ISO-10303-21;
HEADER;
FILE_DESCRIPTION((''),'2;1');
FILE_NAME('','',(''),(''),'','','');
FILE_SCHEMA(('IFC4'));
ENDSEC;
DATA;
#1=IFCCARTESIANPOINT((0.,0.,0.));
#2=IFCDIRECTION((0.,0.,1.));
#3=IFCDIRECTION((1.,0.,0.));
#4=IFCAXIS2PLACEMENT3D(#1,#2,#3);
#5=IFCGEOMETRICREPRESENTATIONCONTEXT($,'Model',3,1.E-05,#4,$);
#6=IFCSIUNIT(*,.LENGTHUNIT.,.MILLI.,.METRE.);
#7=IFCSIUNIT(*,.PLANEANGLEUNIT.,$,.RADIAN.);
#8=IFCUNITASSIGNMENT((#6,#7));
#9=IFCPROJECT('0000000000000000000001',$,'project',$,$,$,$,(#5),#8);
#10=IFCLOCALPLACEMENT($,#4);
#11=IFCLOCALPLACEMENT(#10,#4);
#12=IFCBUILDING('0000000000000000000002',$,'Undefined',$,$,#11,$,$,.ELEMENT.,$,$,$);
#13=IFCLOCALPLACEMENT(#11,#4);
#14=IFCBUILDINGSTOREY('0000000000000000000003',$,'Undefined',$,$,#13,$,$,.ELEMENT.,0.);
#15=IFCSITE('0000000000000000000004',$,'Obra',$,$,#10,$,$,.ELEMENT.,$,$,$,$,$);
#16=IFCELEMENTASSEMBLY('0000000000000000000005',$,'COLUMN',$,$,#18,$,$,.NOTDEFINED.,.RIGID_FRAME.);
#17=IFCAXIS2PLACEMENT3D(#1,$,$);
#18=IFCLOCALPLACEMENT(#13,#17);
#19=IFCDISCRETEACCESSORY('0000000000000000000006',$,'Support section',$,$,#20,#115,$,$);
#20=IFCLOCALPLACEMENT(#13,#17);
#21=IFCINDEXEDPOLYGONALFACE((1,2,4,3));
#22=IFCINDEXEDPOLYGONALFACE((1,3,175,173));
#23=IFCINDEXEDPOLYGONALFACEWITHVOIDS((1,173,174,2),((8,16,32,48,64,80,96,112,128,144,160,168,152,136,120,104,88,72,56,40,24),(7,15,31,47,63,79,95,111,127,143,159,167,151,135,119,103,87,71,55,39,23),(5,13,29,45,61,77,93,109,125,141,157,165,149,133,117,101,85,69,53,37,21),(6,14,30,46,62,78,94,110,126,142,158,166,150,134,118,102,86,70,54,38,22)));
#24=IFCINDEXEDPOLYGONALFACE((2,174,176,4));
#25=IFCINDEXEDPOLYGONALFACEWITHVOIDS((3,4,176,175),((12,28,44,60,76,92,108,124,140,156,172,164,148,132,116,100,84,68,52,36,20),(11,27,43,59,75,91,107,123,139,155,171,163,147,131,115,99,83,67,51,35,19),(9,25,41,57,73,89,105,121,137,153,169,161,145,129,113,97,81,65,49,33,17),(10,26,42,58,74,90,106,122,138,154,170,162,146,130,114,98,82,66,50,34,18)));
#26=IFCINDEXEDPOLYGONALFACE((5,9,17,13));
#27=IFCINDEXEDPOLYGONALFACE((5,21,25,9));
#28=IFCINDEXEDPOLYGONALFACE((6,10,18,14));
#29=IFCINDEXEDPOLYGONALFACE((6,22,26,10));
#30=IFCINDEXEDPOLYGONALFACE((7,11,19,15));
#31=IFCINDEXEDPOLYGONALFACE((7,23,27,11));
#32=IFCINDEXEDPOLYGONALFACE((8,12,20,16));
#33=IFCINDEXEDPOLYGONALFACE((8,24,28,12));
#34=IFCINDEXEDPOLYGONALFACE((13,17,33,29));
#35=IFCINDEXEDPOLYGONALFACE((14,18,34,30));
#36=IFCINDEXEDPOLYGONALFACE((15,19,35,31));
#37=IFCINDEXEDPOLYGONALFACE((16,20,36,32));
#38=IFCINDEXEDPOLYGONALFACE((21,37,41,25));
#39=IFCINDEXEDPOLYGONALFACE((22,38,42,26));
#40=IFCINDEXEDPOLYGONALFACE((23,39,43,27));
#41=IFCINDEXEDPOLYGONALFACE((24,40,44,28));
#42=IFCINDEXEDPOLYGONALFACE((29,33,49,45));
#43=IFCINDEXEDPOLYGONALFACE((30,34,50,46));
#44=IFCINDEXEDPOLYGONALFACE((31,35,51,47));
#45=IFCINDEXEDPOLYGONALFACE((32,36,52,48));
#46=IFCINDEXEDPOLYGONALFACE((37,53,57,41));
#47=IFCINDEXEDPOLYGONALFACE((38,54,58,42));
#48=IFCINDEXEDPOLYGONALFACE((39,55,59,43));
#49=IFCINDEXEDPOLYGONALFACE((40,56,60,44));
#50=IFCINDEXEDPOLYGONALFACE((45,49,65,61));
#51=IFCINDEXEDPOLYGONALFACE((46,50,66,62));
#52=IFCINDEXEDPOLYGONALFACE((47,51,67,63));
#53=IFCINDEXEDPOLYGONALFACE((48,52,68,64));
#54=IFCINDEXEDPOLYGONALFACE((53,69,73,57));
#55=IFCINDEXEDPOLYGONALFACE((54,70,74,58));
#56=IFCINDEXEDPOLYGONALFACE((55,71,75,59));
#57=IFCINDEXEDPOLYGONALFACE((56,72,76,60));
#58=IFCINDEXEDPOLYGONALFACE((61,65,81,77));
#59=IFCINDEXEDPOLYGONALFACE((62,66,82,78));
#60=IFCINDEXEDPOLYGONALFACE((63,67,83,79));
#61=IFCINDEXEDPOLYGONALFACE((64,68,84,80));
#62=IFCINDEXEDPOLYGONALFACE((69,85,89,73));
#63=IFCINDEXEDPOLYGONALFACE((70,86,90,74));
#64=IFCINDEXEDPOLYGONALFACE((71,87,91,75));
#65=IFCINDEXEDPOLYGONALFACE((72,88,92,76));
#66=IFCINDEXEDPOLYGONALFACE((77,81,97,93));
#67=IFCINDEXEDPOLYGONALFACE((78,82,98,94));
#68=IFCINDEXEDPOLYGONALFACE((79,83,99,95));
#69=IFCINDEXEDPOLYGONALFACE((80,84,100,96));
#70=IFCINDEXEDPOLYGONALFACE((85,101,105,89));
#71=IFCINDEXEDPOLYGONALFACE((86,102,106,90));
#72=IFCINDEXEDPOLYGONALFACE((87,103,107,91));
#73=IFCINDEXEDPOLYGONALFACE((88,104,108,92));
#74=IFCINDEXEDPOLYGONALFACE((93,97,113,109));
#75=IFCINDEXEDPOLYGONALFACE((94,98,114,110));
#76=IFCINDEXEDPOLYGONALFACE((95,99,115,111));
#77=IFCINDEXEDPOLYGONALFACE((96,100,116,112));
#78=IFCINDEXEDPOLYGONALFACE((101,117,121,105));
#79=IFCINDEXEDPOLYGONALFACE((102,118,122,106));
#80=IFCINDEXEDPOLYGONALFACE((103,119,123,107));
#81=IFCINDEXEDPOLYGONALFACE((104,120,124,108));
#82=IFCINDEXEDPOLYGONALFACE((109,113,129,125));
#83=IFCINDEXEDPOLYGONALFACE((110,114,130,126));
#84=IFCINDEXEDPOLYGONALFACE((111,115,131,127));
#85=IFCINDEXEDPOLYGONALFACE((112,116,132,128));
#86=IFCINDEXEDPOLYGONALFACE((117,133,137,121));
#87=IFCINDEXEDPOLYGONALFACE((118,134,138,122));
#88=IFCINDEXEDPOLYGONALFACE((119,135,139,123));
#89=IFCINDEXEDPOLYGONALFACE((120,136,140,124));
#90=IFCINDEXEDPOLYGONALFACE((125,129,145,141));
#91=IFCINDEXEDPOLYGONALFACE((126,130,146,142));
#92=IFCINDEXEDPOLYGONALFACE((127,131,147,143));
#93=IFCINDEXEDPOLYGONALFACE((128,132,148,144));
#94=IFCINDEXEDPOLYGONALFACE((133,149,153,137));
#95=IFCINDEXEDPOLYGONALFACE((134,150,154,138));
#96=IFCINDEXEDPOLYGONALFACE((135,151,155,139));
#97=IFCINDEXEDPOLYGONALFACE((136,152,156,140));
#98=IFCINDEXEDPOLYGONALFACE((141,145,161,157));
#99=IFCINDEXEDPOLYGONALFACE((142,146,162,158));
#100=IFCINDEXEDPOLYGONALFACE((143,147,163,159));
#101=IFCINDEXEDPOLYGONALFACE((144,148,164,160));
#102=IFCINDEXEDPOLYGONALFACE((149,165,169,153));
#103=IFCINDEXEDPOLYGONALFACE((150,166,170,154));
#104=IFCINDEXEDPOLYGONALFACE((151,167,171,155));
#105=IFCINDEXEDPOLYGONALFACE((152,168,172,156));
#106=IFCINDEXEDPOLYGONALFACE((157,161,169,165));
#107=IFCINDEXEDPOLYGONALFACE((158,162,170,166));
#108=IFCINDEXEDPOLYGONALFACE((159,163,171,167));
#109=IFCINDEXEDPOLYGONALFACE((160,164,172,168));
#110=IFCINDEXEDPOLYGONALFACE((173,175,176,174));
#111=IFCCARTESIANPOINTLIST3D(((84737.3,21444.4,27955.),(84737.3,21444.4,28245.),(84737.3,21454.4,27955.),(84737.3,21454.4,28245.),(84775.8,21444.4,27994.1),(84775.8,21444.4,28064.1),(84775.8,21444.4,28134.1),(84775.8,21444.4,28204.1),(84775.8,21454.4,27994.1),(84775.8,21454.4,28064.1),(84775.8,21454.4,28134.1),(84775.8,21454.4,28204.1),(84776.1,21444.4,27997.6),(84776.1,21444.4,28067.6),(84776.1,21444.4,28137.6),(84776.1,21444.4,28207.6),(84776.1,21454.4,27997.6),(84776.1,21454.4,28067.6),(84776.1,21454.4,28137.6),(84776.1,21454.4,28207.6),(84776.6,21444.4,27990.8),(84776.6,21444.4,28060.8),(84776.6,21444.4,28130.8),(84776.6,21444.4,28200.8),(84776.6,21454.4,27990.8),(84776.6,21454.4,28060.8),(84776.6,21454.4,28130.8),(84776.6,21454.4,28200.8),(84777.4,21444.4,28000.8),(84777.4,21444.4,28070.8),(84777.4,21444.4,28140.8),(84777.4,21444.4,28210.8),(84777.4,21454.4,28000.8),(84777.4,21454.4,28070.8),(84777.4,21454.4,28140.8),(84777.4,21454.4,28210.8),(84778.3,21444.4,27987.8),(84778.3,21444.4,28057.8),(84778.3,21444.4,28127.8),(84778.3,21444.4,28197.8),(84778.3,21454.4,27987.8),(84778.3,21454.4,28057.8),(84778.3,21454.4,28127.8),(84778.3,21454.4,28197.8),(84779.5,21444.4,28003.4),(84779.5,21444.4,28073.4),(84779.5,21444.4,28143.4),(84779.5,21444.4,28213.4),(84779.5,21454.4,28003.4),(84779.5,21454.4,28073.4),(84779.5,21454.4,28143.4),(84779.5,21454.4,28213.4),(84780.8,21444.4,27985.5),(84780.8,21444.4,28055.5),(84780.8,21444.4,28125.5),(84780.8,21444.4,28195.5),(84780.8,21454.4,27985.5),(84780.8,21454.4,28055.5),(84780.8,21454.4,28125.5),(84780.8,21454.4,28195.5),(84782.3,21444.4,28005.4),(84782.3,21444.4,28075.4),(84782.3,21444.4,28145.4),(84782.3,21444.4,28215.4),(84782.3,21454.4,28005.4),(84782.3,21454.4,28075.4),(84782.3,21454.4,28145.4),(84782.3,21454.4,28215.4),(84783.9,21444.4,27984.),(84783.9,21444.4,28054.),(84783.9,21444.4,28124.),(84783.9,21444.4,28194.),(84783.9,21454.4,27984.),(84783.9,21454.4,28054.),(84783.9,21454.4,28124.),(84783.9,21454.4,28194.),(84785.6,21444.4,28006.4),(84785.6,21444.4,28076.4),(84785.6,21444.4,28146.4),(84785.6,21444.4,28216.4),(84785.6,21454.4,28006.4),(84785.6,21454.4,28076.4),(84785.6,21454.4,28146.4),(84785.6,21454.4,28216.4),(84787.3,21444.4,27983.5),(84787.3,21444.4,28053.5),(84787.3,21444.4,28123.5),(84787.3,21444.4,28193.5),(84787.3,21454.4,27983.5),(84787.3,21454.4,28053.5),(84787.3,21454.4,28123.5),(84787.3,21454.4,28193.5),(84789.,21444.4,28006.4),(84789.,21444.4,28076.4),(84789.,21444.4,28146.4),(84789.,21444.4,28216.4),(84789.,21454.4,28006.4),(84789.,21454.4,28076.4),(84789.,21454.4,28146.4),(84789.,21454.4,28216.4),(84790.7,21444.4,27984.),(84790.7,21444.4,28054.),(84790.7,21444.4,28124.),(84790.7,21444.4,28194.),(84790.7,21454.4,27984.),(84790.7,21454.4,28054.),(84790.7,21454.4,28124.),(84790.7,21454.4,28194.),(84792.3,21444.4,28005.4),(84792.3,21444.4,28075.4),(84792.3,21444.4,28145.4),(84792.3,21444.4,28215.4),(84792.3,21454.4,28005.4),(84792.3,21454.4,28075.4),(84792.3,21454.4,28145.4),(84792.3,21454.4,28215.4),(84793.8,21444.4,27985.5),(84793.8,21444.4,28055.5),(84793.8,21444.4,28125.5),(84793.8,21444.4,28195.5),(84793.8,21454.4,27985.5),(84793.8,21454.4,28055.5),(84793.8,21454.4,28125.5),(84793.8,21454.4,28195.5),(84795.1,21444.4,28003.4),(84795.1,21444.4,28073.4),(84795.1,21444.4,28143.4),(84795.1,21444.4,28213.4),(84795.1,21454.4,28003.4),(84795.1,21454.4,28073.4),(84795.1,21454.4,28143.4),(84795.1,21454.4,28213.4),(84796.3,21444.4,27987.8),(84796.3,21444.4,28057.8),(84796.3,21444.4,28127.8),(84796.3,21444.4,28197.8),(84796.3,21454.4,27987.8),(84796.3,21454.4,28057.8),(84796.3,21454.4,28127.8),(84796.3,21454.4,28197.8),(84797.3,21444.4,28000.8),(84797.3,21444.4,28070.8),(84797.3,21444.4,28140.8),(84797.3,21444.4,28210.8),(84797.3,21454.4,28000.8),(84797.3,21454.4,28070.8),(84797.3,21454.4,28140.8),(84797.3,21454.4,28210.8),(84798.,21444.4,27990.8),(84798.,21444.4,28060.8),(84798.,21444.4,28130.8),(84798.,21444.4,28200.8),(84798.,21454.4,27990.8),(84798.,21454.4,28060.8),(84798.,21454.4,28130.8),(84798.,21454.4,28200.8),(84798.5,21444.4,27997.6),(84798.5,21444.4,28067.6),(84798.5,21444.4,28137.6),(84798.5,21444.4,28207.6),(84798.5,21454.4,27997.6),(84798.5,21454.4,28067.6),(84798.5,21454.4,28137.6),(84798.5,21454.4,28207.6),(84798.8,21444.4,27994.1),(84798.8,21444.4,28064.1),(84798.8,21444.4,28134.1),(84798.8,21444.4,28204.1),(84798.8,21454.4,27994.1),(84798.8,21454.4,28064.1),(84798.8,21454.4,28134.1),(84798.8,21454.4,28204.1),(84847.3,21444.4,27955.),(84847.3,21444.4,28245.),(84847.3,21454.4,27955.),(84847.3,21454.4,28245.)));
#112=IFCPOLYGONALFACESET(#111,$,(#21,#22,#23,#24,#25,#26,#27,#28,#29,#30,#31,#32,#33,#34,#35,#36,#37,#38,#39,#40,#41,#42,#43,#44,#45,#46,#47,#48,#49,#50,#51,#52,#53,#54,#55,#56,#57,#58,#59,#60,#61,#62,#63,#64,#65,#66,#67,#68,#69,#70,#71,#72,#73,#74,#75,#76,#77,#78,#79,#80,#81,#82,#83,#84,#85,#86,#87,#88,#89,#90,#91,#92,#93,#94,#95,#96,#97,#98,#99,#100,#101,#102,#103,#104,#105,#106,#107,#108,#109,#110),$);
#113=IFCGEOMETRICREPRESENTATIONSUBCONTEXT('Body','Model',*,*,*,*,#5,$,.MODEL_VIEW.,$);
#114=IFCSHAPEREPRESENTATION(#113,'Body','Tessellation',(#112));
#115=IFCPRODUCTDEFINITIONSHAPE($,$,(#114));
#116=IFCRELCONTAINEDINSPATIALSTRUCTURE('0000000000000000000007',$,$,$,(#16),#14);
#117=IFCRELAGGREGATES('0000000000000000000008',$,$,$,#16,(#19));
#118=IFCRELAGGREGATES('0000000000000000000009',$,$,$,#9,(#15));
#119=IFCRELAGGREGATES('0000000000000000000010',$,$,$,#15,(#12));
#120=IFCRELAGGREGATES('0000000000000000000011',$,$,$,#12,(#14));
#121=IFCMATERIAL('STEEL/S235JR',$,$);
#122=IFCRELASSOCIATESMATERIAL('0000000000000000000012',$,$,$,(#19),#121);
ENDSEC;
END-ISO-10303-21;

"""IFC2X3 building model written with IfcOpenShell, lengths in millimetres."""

from ifc_helpers import new_model, si_unit, frame, origin_with_axes, origin_2d_with_axis, place, context, subcontext, project, spatial, rectangle, circle, extrude, source, transform, mapped, material, element, aggregate, save


model = new_model("IFC2X3")

# Units and contexts
model_context = context("Model", 3, precision=1e-05, world=origin_with_axes())
body_context = subcontext(model_context, "Body", "Model", "MODEL_VIEW")
ifc_project = project(units=[si_unit("LENGTHUNIT", "METRE", prefix="MILLI"), si_unit("PLANEANGLEUNIT", "RADIAN")], contexts=[model_context])

# Site, building, storey
site_placement = place(None, origin_with_axes())
site = spatial("IfcSite", under=ifc_project, at=site_placement, Name="Obra", CompositionType="ELEMENT")
building_placement = place(site_placement, origin_with_axes())
building = spatial("IfcBuilding", under=site, at=building_placement, Name="Undefined", CompositionType="ELEMENT")
storey_placement = place(building_placement, origin_with_axes())
storey = spatial("IfcBuildingStorey", under=building, at=storey_placement, Name="Undefined", CompositionType="ELEMENT", Elevation=0.0)

# Element assembly
ifc_material = material(Name="STEEL/S235JR")
assembly_1_placement = place(storey_placement, origin_with_axes())
assembly_1 = element("IfcElementAssembly", 1, at=assembly_1_placement, inside=storey, Name="COLUMN", AssemblyPlace="NOTDEFINED", PredefinedType="RIGID_FRAME")

# Discrete accessory, opening
shared_shape_1 = source(origin_with_axes(), body_context, "Body", "SweptSolid", [
    extrude(circle(Radius=11.5, at=origin_2d_with_axis()), frame((0.0, -14.4, 0.0), z_axis=(0.0, 1.0, 0.0), x_axis=(1.0, 0.0, 0.0)), (0.0, 0.0, 1.0), 10.2),
])
discrete_accessory_1_placement = place(assembly_1_placement, frame((84792.3, 21449.4, 27955.0), z_axis=(0.0, 0.0, 1.0), x_axis=(1.0, 0.0, 0.0)))
discrete_accessory_1 = element("IfcDiscreteAccessory", 2, at=discrete_accessory_1_placement, material=ifc_material, Name="Support section", context=body_context, shape_type="SweptSolid", body=[
    extrude(rectangle(XDim=10.0, YDim=110.0, at=origin_2d_with_axis()), frame((0.0, 0.0, 290.0), z_axis=(0.0, 0.0, -1.0), x_axis=(0.0, 1.0, 0.0)), (0.0, 0.0, 1.0), 290.0),
])
opening_1_placement = place(assembly_1_placement, frame((84837.3, 21440.1, 28300.0), z_axis=(-1.0, 0.0, 0.0), x_axis=(0.0, 0.0, -1.0)))
element("IfcOpeningElement", 3, at=opening_1_placement, cuts=discrete_accessory_1, ObjectType="Opening", context=body_context, shape_type="MappedRepresentation", body=[
    mapped(shared_shape_1, transform((95.0, 0.0, 50.0))),
    mapped(shared_shape_1, transform((165.0, 0.0, 50.0))),
    mapped(shared_shape_1, transform((235.0, 0.0, 50.0))),
    mapped(shared_shape_1, transform((305.0, 0.0, 50.0))),
])
aggregate(assembly_1, [discrete_accessory_1])

save(model, "model.ifc")
